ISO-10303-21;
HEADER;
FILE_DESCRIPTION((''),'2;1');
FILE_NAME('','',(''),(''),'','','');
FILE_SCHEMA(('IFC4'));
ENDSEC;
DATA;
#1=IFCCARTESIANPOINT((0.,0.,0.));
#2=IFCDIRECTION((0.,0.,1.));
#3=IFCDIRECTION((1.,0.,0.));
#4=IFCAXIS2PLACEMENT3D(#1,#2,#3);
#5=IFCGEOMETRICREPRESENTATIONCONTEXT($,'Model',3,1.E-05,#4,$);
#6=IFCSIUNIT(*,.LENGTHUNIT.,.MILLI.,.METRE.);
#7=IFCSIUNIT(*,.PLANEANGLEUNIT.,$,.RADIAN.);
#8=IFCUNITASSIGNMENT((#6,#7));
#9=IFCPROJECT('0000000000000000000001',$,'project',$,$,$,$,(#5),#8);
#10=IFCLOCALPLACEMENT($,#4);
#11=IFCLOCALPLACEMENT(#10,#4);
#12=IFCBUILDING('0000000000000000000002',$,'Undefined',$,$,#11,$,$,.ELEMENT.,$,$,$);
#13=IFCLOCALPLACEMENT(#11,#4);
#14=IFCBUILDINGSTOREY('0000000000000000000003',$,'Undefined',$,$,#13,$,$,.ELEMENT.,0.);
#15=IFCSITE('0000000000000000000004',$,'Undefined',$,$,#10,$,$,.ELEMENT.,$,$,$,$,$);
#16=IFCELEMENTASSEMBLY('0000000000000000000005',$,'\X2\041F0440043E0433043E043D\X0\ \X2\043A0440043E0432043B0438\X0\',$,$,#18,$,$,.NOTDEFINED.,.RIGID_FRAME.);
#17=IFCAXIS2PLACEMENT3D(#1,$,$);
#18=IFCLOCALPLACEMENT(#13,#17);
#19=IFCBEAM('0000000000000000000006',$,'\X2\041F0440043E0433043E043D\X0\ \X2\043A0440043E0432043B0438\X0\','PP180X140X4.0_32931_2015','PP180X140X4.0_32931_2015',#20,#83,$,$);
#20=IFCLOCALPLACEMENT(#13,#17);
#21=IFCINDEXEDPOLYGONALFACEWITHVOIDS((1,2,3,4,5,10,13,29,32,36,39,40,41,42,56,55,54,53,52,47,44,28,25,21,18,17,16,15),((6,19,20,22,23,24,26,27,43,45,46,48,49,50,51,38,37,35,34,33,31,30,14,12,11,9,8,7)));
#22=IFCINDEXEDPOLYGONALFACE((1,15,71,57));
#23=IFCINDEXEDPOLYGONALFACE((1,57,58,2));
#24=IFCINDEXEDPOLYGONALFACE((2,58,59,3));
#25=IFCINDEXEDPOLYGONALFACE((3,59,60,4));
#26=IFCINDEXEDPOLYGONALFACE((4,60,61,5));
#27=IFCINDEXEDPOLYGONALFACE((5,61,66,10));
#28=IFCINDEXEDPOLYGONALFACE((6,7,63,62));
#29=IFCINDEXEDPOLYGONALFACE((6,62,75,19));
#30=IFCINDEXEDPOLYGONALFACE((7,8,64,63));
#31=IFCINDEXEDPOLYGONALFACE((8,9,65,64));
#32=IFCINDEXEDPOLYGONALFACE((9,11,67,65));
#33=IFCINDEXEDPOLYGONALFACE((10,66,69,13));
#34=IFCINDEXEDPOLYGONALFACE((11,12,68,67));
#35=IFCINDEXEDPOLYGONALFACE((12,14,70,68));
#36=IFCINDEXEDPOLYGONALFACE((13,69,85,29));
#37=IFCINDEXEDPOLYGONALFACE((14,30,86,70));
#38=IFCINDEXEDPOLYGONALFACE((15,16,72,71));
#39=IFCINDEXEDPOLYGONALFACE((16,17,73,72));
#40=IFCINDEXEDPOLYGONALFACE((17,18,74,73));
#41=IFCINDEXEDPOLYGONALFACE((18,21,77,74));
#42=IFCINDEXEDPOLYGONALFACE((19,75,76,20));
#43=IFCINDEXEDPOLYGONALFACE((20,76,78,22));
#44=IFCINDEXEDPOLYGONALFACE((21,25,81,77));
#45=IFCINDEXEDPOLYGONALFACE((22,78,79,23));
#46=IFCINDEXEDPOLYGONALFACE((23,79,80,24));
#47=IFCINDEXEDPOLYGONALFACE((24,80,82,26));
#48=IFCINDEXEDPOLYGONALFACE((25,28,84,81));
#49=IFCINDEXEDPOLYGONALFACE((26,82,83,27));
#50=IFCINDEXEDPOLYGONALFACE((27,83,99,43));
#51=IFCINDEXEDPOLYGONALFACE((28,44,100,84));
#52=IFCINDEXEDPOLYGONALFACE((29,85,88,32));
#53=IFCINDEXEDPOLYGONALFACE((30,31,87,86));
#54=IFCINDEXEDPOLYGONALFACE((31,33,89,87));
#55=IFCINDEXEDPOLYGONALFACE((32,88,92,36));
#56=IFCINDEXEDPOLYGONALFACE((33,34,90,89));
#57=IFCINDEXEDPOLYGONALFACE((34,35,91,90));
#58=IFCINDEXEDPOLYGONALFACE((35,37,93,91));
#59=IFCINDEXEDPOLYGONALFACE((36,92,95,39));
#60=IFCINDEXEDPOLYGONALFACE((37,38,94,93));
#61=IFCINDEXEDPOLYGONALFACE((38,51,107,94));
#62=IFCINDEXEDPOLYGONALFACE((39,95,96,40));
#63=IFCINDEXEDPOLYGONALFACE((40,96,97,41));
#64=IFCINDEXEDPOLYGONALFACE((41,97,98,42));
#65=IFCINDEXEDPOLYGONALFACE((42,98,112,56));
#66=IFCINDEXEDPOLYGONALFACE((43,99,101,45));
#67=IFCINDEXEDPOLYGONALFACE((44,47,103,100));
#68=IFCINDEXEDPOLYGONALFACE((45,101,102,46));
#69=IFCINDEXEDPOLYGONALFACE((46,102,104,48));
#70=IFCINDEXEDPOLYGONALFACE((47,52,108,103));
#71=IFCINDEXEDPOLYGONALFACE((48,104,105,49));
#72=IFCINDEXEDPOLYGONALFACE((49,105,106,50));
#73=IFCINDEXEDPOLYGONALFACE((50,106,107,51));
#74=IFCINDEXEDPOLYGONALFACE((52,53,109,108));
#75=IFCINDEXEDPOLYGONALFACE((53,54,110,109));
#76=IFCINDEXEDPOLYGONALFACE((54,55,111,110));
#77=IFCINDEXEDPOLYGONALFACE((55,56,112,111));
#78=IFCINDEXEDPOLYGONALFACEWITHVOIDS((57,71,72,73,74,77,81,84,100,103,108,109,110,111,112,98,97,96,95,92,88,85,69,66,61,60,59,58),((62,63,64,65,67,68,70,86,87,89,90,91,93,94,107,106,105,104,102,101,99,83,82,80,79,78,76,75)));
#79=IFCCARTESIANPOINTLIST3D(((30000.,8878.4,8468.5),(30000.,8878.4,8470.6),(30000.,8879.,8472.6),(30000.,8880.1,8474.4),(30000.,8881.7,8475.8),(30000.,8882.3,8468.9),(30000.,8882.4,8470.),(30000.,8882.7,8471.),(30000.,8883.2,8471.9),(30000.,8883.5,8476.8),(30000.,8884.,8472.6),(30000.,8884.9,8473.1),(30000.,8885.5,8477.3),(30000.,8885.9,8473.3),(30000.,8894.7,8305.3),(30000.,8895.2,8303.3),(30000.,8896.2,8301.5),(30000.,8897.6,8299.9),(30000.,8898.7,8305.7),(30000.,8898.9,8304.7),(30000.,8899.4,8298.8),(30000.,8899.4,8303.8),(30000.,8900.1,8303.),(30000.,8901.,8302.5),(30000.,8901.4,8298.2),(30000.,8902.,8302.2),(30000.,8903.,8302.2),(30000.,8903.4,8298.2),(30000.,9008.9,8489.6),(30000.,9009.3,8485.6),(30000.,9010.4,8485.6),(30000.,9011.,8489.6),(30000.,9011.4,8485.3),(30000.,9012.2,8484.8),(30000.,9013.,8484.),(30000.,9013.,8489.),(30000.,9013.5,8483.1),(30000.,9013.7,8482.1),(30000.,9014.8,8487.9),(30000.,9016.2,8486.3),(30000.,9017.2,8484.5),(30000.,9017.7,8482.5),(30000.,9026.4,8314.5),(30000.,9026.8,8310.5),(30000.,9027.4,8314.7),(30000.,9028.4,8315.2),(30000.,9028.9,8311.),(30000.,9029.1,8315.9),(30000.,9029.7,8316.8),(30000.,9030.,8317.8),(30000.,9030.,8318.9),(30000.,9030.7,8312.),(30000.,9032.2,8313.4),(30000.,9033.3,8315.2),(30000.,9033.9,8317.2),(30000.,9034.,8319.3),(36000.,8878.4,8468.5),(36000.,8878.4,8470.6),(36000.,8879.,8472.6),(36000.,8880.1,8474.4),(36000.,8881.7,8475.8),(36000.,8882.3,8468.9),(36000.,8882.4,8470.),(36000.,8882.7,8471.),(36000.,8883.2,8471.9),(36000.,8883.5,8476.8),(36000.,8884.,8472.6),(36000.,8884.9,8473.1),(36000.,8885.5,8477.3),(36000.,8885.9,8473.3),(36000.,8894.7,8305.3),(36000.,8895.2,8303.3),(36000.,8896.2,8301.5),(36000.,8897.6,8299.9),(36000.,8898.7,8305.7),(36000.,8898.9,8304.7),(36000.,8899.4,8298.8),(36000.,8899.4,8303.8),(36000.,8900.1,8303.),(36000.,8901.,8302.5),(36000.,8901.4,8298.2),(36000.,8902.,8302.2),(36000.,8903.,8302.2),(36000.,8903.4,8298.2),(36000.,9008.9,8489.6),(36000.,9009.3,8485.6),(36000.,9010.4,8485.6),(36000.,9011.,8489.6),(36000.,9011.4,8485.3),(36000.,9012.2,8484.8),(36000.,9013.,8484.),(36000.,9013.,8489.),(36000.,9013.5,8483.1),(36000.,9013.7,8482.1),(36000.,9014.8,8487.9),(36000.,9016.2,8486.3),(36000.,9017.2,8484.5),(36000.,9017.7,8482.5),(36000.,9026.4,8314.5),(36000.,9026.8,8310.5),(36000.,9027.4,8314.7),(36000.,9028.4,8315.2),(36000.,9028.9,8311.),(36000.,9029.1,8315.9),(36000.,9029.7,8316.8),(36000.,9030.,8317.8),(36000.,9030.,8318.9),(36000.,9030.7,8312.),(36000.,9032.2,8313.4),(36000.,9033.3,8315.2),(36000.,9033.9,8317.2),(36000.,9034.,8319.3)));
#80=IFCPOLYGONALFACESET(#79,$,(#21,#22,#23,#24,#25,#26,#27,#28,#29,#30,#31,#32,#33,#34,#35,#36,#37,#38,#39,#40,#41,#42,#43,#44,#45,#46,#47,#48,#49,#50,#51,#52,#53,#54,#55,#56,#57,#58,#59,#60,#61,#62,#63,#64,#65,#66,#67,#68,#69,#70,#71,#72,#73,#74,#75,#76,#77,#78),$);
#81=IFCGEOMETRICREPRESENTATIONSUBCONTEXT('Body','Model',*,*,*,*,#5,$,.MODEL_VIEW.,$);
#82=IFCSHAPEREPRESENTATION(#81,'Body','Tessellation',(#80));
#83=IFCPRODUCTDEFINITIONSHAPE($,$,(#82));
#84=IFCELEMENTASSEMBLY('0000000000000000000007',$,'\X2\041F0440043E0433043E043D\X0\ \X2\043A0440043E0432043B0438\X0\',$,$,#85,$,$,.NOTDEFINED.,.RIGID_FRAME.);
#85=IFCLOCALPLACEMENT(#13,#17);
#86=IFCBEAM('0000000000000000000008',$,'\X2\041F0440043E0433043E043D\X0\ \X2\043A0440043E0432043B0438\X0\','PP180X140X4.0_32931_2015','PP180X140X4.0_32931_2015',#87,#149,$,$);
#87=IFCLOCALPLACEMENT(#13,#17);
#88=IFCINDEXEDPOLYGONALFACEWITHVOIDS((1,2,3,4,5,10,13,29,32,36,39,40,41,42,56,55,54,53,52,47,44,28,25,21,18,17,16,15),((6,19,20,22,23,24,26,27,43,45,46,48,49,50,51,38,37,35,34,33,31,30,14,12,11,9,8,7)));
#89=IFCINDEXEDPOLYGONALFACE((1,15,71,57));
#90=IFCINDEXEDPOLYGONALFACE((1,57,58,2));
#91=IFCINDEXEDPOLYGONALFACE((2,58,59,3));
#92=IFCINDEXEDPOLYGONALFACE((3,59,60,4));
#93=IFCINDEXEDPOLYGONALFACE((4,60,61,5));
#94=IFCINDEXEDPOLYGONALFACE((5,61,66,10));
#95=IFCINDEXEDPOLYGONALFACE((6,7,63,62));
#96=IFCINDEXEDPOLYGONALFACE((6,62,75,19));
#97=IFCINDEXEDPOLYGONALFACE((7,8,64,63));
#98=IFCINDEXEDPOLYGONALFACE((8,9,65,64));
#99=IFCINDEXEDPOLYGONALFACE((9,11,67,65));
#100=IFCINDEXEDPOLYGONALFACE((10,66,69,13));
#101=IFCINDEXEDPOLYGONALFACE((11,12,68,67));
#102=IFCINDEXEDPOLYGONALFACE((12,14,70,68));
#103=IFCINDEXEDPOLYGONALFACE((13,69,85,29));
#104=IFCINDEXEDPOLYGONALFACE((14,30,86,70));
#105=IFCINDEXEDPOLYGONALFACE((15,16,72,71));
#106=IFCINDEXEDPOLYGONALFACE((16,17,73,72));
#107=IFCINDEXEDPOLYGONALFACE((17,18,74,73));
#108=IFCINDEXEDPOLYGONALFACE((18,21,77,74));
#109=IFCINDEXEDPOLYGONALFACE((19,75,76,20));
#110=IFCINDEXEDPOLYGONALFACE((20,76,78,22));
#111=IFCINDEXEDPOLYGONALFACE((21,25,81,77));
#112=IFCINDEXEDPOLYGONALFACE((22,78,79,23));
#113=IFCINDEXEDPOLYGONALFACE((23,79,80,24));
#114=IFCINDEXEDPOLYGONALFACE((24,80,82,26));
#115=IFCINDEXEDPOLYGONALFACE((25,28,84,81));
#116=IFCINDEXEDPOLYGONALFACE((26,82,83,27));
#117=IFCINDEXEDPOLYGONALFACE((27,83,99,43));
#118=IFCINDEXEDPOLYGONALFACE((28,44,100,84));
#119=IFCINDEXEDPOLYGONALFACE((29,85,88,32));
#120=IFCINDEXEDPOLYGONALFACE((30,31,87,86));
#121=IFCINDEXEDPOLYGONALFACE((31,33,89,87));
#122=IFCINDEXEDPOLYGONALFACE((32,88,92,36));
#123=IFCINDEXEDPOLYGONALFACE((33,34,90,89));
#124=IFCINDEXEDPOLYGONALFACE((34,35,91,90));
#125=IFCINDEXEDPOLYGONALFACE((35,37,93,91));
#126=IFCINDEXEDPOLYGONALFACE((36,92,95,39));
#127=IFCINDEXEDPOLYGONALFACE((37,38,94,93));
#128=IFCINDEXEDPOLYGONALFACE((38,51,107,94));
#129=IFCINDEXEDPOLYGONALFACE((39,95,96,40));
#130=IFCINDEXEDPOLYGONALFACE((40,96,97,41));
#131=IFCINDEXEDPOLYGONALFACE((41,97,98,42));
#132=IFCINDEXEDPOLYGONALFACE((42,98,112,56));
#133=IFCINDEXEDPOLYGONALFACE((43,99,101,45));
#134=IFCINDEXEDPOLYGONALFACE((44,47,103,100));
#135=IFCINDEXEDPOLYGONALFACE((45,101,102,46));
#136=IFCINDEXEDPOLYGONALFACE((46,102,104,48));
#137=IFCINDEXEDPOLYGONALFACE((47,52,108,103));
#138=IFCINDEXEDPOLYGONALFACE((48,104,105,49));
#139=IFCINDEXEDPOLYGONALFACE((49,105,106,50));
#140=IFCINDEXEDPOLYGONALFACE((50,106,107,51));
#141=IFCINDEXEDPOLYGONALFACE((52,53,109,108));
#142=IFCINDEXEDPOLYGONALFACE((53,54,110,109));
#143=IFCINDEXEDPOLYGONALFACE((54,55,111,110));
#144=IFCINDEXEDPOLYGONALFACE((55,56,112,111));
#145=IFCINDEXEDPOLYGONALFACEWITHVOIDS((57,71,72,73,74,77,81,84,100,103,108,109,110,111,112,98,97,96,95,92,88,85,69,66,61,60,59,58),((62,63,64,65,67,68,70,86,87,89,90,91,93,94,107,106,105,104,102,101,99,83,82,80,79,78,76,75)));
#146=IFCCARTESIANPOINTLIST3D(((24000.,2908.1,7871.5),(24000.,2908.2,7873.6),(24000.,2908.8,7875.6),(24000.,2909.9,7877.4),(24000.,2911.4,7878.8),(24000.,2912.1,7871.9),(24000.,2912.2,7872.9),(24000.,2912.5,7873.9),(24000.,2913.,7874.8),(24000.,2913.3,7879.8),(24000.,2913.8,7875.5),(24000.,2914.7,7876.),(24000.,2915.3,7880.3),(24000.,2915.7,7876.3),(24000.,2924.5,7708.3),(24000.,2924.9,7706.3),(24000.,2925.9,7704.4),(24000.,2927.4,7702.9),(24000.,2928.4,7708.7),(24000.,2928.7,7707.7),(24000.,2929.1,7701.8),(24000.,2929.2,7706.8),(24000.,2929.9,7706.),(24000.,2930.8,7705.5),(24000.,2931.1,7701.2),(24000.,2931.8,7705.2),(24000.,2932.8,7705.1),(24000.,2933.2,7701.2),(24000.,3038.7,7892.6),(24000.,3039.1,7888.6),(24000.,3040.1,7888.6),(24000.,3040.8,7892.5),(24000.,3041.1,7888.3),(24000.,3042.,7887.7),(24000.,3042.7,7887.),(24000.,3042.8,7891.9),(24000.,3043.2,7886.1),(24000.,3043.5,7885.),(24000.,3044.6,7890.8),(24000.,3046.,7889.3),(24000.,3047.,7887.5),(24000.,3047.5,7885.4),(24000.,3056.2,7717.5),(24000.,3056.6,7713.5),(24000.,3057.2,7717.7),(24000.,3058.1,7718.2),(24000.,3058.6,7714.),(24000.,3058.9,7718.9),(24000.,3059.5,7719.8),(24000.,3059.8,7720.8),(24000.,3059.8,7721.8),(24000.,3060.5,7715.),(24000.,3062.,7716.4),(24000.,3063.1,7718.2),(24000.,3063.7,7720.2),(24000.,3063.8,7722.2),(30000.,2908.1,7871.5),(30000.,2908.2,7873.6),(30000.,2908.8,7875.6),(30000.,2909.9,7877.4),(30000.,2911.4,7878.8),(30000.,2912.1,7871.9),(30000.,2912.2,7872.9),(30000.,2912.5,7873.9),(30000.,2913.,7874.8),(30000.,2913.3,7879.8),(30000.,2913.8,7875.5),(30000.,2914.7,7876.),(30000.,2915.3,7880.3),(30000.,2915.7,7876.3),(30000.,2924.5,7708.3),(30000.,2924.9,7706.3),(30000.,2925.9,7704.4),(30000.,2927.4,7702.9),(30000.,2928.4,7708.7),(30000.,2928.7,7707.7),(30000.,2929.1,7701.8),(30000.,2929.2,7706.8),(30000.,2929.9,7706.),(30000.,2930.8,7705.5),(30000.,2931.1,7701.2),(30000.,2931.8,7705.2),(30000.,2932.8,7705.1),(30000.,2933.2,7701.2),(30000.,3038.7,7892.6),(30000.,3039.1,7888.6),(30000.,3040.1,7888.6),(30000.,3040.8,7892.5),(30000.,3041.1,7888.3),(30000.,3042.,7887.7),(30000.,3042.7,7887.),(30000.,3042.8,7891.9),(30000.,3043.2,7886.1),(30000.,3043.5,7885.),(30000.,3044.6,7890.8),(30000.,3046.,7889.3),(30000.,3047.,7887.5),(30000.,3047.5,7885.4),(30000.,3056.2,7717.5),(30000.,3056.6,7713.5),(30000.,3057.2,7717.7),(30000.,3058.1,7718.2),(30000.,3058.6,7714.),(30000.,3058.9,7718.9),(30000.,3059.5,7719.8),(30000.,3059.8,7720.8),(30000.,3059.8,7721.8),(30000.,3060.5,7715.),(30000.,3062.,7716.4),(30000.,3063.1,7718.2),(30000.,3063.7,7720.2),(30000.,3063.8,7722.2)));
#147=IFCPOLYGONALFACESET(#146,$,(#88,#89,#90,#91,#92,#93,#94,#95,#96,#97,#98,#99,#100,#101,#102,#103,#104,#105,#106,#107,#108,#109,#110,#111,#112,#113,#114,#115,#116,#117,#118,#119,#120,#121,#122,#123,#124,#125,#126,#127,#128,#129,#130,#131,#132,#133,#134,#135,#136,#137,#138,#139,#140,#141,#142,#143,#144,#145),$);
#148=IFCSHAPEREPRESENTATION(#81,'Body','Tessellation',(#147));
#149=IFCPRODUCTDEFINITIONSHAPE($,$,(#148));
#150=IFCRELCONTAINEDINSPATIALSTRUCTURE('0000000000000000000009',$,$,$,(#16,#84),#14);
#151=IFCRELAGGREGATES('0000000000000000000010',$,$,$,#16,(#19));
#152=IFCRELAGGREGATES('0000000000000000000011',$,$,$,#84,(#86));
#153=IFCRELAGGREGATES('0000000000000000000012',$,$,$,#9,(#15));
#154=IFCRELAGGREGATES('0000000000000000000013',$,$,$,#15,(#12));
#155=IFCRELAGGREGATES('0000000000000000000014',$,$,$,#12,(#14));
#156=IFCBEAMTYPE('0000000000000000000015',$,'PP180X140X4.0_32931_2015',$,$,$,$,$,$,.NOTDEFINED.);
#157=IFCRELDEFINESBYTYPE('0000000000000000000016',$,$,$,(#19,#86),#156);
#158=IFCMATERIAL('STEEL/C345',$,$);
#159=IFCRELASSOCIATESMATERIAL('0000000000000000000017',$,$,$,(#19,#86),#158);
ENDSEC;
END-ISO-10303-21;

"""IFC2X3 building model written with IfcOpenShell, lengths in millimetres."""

from ifc_helpers import new_model, si_unit, frame, origin_with_axes, origin_2d_with_axis, place, context, subcontext, project, spatial, hollow_rectangle, extrude, material, type_object, element, aggregate, save


model = new_model("IFC2X3")

# Units and contexts
model_context = context("Model", 3, precision=1e-05, world=origin_with_axes())
body_context = subcontext(model_context, "Body", "Model", "MODEL_VIEW")
ifc_project = project(units=[si_unit("LENGTHUNIT", "METRE", prefix="MILLI"), si_unit("PLANEANGLEUNIT", "RADIAN")], contexts=[model_context])

# Site, building, storey
site_placement = place(None, origin_with_axes())
site = spatial("IfcSite", under=ifc_project, at=site_placement, Name="Undefined", CompositionType="ELEMENT")
building_placement = place(site_placement, origin_with_axes())
building = spatial("IfcBuilding", under=site, at=building_placement, Name="Undefined", CompositionType="ELEMENT")
storey_placement = place(building_placement, origin_with_axes())
storey = spatial("IfcBuildingStorey", under=building, at=storey_placement, Name="Undefined", CompositionType="ELEMENT", Elevation=0.0)

# Element assemblies, beams
ifc_material_1 = material(Name="STEEL/C345")
beam_type_1 = type_object("IfcBeamType", Name="PP180X140X4.0_32931_2015", PredefinedType="NOTDEFINED")
assembly_1_placement = place(storey_placement, origin_with_axes())
assembly_1 = element("IfcElementAssembly", 1, at=assembly_1_placement, inside=storey, Name="Прогон кровли", AssemblyPlace="NOTDEFINED", PredefinedType="RIGID_FRAME")
beam_1_placement = place(assembly_1_placement, frame((30000.0, 8956.2, 8393.9), z_axis=(0.0, -0.099504, 0.995037), x_axis=(1.0, 0.0, 0.0)))
beam_1 = element("IfcBeam", 2, at=beam_1_placement, type_object=beam_type_1, material=ifc_material_1, Name="Прогон кровли", Description="PP180X140X4.0_32931_2015", ObjectType="PP180X140X4.0_32931_2015", context=body_context, shape_type="SweptSolid", body=[
    extrude(hollow_rectangle(XDim=140.0, YDim=180.0, WallThickness=4.0, InnerFilletRadius=4.0, OuterFilletRadius=8.0, at=origin_2d_with_axis()), frame((6000.0, 0.0, 0.0), z_axis=(-1.0, 0.0, 0.0), x_axis=(0.0, -1.0, 0.0)), (0.0, 0.0, 1.0), 6000.0),
])
aggregate(assembly_1, [beam_1])
assembly_2_placement = place(storey_placement, origin_with_axes())
assembly_2 = element("IfcElementAssembly", 3, at=assembly_2_placement, inside=storey, Name="Прогон кровли", AssemblyPlace="NOTDEFINED", PredefinedType="RIGID_FRAME")
beam_2_placement = place(assembly_2_placement, frame((24000.0, 2986.0, 7796.9), z_axis=(0.0, -0.099504, 0.995037), x_axis=(1.0, 0.0, 0.0)))
beam_2 = element("IfcBeam", 4, at=beam_2_placement, type_object=beam_type_1, material=ifc_material_1, Name="Прогон кровли", Description="PP180X140X4.0_32931_2015", ObjectType="PP180X140X4.0_32931_2015", context=body_context, shape_type="SweptSolid", body=[
    extrude(hollow_rectangle(XDim=140.0, YDim=180.0, WallThickness=4.0, InnerFilletRadius=4.0, OuterFilletRadius=8.0, at=origin_2d_with_axis()), frame((6000.0, 0.0, 0.0), z_axis=(-1.0, 0.0, 0.0), x_axis=(0.0, -1.0, 0.0)), (0.0, 0.0, 1.0), 6000.0),
])
aggregate(assembly_2, [beam_2])

save(model, "model.ifc")
